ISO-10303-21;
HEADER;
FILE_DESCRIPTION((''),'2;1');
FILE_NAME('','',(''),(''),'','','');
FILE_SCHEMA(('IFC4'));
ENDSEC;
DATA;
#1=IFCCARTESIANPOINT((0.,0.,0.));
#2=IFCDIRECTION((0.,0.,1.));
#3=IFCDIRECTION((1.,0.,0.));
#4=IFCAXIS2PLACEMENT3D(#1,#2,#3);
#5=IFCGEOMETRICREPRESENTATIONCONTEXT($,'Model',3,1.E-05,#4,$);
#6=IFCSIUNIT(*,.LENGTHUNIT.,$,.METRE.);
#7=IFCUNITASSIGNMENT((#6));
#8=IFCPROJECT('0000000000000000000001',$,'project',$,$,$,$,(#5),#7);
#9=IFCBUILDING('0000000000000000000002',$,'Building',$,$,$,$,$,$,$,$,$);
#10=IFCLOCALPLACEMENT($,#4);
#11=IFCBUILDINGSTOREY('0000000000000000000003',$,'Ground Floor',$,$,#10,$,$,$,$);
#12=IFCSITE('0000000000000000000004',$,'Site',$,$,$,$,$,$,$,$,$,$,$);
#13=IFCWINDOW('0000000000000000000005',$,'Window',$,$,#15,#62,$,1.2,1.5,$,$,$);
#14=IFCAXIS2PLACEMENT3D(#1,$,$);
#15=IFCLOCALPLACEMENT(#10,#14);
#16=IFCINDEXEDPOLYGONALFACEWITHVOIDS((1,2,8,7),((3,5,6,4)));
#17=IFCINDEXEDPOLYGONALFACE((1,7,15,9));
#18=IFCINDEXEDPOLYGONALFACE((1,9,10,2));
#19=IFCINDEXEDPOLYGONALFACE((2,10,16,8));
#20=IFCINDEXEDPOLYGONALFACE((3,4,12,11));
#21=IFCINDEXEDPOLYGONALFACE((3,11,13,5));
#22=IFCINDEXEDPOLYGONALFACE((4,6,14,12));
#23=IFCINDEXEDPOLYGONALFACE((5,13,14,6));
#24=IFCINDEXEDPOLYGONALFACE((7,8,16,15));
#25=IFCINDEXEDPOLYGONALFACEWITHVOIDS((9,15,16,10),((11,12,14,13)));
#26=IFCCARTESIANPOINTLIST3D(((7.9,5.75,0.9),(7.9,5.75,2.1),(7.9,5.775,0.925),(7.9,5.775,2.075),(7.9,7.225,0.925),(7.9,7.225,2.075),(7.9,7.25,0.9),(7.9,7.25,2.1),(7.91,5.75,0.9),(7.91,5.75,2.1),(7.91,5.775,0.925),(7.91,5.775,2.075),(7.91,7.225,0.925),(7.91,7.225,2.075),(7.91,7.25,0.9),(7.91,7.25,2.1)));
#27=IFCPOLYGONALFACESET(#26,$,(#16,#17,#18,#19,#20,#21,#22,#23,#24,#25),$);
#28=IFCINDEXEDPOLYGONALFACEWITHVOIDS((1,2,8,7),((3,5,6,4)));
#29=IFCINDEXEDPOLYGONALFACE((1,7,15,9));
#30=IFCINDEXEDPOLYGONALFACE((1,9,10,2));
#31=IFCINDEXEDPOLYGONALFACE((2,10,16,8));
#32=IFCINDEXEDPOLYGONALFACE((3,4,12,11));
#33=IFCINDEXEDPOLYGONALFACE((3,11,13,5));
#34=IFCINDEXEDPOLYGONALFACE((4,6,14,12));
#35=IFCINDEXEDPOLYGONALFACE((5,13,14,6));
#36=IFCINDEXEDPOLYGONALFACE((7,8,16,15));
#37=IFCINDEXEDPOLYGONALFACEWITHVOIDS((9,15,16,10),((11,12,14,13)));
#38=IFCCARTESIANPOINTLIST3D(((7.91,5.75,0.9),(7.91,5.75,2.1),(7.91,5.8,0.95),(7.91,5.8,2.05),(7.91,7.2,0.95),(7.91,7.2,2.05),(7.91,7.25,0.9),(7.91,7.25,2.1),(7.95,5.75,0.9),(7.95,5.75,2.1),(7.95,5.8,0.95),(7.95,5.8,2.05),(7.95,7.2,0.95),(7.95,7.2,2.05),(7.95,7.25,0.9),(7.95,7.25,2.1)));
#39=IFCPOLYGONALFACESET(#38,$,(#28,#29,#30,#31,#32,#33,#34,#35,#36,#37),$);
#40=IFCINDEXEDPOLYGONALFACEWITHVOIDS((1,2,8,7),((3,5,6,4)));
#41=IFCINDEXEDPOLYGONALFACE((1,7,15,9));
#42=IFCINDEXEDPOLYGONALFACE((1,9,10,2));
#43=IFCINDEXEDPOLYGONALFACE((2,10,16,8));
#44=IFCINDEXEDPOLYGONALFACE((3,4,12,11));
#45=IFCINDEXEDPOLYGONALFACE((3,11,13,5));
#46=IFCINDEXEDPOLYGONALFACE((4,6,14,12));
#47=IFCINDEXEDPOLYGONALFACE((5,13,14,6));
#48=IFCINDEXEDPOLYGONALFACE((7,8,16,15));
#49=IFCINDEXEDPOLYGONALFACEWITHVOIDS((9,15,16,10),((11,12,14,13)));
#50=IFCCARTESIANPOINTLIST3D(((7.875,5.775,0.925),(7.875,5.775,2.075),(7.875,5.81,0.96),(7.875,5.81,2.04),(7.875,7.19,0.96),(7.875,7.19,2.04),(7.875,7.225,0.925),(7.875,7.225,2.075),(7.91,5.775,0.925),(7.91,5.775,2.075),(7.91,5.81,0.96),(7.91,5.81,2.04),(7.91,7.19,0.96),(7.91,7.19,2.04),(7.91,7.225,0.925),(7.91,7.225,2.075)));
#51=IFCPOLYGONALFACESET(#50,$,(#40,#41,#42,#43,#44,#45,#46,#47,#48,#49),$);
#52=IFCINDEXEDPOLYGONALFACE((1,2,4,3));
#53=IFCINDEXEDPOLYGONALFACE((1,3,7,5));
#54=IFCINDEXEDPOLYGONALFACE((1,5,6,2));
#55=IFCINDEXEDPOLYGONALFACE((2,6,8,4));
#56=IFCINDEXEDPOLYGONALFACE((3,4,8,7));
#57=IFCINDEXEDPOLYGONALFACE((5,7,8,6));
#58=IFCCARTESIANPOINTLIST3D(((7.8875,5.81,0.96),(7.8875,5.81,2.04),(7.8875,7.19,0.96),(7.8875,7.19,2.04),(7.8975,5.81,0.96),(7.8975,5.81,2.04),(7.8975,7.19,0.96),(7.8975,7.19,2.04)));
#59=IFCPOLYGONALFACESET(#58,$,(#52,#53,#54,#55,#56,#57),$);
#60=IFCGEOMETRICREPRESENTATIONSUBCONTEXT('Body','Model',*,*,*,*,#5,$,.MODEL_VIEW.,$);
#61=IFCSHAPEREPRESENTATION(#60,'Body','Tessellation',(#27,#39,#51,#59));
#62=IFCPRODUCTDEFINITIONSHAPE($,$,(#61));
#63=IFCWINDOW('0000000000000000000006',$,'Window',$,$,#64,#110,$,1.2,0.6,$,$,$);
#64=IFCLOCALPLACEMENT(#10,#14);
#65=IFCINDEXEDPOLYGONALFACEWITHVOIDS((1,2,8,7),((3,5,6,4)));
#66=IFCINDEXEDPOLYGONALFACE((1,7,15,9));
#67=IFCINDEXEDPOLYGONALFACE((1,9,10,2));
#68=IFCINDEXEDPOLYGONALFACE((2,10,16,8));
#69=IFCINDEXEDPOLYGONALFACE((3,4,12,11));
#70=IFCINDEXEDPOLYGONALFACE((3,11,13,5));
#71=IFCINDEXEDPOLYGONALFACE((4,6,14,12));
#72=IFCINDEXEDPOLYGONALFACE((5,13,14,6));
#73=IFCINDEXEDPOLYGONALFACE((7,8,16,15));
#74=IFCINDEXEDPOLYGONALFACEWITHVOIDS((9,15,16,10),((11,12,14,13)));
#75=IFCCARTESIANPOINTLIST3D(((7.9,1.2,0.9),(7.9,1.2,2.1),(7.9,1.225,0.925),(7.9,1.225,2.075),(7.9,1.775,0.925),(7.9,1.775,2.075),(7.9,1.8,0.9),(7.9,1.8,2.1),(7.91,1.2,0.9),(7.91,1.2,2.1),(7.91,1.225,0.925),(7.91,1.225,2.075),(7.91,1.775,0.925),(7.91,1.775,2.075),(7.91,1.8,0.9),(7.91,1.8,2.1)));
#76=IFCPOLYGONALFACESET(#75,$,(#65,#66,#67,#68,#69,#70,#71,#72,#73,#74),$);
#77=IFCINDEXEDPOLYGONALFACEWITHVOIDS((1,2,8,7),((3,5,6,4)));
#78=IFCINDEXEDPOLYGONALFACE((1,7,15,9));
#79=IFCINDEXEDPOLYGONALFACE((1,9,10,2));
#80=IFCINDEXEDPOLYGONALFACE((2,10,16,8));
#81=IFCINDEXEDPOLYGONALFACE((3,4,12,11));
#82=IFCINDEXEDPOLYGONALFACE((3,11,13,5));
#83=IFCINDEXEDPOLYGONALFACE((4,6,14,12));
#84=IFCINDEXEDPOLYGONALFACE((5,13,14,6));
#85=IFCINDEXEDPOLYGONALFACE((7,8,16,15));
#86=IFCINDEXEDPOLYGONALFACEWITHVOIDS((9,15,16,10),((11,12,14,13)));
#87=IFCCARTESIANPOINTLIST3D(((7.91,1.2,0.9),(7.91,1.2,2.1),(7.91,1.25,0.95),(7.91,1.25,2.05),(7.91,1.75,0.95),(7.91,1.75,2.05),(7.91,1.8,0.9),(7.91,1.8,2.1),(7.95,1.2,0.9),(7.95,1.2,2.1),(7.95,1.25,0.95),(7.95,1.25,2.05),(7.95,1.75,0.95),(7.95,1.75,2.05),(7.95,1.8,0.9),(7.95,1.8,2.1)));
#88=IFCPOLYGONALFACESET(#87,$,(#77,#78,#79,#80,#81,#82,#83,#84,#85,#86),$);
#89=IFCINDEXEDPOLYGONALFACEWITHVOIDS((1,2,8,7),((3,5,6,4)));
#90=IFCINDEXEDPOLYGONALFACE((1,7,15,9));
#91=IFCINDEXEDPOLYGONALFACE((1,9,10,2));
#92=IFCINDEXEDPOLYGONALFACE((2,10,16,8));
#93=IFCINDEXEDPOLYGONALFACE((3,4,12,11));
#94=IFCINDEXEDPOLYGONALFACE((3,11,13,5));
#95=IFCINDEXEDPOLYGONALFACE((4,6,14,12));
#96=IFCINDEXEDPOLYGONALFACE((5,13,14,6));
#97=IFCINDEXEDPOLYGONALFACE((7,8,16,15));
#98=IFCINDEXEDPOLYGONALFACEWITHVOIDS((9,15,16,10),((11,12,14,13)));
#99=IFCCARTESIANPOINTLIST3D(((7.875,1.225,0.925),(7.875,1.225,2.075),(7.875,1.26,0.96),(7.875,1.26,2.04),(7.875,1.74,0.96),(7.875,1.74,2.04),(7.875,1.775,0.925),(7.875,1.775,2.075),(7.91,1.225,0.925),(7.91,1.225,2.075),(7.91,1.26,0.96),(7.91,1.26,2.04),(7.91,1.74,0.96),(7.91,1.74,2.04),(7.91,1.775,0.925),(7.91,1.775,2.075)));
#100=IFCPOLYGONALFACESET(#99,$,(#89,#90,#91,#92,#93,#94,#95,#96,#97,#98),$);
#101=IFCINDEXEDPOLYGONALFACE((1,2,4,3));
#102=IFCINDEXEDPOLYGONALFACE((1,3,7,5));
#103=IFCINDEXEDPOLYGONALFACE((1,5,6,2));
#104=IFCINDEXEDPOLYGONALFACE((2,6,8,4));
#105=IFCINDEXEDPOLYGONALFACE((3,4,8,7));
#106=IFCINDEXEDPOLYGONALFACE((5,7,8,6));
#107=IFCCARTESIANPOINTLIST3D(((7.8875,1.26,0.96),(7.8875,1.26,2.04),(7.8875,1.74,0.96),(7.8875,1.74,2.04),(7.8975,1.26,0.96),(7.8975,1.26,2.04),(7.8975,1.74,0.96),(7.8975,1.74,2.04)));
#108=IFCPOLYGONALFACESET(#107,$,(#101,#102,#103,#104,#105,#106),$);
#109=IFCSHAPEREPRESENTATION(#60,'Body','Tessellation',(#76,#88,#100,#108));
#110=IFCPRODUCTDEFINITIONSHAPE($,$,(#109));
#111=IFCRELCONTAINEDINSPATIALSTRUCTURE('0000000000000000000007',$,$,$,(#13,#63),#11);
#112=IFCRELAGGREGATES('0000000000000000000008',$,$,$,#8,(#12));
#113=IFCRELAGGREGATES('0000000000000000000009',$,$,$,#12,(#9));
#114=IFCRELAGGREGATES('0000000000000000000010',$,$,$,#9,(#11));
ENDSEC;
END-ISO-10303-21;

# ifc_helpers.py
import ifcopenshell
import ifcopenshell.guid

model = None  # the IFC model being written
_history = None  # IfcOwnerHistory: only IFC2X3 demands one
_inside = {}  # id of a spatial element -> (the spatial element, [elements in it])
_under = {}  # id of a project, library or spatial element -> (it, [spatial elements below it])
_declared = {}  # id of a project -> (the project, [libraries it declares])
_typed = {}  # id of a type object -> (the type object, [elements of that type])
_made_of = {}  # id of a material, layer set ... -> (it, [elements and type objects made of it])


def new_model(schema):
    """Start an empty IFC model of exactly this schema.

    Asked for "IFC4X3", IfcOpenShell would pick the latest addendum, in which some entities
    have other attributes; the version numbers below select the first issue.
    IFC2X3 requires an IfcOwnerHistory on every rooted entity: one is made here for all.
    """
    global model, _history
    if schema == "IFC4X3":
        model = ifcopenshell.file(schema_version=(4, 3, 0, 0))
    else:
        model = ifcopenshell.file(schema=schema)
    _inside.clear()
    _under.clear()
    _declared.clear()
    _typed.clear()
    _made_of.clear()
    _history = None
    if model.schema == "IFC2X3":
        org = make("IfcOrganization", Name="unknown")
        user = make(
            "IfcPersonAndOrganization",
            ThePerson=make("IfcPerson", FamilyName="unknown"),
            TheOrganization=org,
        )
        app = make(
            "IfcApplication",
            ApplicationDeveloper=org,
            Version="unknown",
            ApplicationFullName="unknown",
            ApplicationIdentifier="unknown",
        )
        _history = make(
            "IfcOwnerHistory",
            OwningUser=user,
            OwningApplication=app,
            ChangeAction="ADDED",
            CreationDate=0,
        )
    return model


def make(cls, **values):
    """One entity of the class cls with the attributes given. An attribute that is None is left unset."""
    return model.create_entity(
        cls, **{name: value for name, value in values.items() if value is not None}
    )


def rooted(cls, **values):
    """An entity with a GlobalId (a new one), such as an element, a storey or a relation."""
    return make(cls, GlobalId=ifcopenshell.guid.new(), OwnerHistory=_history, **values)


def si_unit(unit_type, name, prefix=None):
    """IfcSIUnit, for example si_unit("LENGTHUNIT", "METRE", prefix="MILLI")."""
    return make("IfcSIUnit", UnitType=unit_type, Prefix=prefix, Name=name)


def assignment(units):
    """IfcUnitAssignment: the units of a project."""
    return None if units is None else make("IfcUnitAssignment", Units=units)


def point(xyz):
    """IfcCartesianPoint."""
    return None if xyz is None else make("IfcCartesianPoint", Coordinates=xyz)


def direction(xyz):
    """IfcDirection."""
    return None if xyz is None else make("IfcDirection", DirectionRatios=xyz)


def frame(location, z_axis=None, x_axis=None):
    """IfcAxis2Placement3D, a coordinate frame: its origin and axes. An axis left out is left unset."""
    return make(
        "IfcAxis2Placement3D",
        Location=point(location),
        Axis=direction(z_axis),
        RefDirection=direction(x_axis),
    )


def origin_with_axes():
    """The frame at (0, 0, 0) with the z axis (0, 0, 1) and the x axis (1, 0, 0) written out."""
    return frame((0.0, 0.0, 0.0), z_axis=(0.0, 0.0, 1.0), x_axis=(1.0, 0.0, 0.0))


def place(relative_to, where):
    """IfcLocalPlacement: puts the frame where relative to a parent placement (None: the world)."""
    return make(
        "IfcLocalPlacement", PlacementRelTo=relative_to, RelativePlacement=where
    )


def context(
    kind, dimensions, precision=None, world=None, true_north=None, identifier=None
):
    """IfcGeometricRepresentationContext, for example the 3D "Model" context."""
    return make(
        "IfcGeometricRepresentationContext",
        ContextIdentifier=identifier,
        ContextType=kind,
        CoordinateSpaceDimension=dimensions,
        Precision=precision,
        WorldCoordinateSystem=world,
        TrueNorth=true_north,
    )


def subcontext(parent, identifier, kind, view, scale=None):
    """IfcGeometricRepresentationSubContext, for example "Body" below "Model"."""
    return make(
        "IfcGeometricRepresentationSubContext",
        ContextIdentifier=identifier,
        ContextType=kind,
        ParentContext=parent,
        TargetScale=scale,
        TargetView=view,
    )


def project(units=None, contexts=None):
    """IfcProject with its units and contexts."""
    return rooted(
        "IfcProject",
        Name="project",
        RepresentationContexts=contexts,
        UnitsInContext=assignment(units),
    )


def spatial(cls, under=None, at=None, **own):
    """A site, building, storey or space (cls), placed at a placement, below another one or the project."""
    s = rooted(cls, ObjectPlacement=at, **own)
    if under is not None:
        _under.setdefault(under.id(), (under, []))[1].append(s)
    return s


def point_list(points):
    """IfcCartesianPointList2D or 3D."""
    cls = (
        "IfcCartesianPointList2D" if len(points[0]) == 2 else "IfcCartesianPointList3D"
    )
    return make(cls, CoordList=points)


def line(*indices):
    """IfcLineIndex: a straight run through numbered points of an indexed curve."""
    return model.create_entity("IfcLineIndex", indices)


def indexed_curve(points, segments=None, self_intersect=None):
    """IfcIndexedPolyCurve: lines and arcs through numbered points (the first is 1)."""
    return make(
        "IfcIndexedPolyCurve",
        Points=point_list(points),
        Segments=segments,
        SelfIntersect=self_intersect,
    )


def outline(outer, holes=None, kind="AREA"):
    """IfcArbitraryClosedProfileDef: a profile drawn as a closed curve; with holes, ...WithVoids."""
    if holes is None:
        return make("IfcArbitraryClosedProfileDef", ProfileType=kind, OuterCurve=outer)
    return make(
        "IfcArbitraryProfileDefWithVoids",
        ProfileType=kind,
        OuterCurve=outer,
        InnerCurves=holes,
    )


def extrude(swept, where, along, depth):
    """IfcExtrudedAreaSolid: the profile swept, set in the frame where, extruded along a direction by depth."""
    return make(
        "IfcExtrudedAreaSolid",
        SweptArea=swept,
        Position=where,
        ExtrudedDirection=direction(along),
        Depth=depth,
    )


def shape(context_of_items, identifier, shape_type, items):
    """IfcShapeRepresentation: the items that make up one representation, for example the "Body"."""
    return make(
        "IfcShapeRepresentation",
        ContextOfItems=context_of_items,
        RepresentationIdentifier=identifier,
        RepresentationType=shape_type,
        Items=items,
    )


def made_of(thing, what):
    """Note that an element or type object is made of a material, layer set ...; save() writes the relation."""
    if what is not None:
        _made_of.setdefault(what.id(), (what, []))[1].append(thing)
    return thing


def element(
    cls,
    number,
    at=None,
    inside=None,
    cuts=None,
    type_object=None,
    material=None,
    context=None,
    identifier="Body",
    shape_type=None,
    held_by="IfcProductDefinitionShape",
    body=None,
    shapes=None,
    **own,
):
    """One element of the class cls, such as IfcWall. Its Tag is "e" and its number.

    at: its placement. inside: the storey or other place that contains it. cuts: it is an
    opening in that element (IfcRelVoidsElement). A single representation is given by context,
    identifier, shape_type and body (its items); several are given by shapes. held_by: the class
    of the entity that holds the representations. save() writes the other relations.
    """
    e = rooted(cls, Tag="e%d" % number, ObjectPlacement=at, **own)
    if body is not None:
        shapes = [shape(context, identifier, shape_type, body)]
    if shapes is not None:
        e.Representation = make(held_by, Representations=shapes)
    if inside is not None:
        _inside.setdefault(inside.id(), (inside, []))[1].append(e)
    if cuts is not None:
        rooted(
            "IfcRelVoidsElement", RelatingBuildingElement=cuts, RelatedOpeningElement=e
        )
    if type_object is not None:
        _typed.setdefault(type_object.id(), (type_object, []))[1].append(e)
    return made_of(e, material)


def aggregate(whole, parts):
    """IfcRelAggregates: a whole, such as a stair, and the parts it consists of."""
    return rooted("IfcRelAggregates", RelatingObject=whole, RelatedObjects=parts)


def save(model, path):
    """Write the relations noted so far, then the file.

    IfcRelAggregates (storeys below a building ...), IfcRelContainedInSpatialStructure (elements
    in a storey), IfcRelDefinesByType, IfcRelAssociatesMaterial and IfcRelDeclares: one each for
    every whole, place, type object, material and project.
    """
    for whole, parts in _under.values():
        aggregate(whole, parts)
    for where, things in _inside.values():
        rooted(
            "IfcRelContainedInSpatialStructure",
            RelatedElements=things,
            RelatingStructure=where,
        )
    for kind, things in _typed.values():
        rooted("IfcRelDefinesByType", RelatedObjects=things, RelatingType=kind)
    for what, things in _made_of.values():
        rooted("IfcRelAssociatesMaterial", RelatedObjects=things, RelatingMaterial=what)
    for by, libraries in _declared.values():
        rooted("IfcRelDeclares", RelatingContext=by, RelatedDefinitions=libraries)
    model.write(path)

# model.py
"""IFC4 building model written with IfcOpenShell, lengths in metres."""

from ifc_helpers import new_model, si_unit, frame, origin_with_axes, place, context, subcontext, project, spatial, line, indexed_curve, outline, extrude, element, save


model = new_model("IFC4")

# Units and contexts
model_context = context("Model", 3, precision=1e-05, world=origin_with_axes())
body_context = subcontext(model_context, "Body", "Model", "MODEL_VIEW")
ifc_project = project(units=[si_unit("LENGTHUNIT", "METRE")], contexts=[model_context])

# Site, building, storey
site = spatial("IfcSite", under=ifc_project, Name="Site")
building = spatial("IfcBuilding", under=site, Name="Building")
storey_placement = place(None, origin_with_axes())
storey = spatial("IfcBuildingStorey", under=building, at=storey_placement, Name="Ground Floor")

# Windows
for number, where, z_axis, x_axis, name in (
    (1, (8.0, 5.75, 0.9), (0.0, 0.0, 1.0), (0.0, 1.0, 0.0), "Window"),
):
    element("IfcWindow", number, at=place(storey_placement, frame(where, z_axis=z_axis, x_axis=x_axis)), inside=storey, Name=name, OverallHeight=1.2, OverallWidth=1.5, context=body_context, shape_type="SweptSolid", body=[
        extrude(outline(indexed_curve([(0.0, 0.0), (1.5, 0.0), (1.5, 1.2), (0.0, 1.2)], segments=[line(1, 2, 3, 4, 1)]), holes=[indexed_curve([(0.025, 0.025), (1.475, 0.025), (1.475, 1.175), (0.025, 1.175)], segments=[line(1, 2, 3, 4, 1)])]), frame((0.0, 0.09, 0.0), z_axis=(0.0, -1.0, 0.0), x_axis=(1.0, 0.0, 0.0)), (0.0, 0.0, -1.0), 0.01),
        extrude(outline(indexed_curve([(0.0, 0.0), (1.5, 0.0), (1.5, 1.2), (0.0, 1.2)], segments=[line(1, 2, 3, 4, 1)]), holes=[indexed_curve([(0.05, 0.05), (1.45, 0.05), (1.45, 1.15), (0.05, 1.15)], segments=[line(1, 2, 3, 4, 1)])]), frame((0.0, 0.05, 0.0), z_axis=(0.0, -1.0, 0.0), x_axis=(1.0, 0.0, 0.0)), (0.0, 0.0, -1.0), 0.04),
        extrude(outline(indexed_curve([(0.0, 0.0), (1.45, 0.0), (1.45, 1.15), (0.0, 1.15)], segments=[line(1, 2, 3, 4, 1)]), holes=[indexed_curve([(0.035, 0.035), (1.415, 0.035), (1.415, 1.115), (0.035, 1.115)], segments=[line(1, 2, 3, 4, 1)])]), frame((0.025, 0.09, 0.025), z_axis=(0.0, -1.0, 0.0), x_axis=(1.0, 0.0, 0.0)), (0.0, 0.0, -1.0), 0.035),
        extrude(outline(indexed_curve([(0.035, 0.035), (1.415, 0.035), (1.415, 1.115), (0.035, 1.115)], segments=[line(1, 2, 3, 4, 1)])), frame((0.025, 0.1025, 0.025), z_axis=(0.0, -1.0, 0.0), x_axis=(1.0, 0.0, 0.0)), (0.0, 0.0, -1.0), 0.01),
    ])
window_1_placement = place(storey_placement, frame((8.0, 1.2, 0.9), z_axis=(0.0, 0.0, 1.0), x_axis=(0.0, 1.0, 0.0)))
element("IfcWindow", 2, at=window_1_placement, inside=storey, Name="Window", OverallHeight=1.2, OverallWidth=0.6, context=body_context, shape_type="SweptSolid", body=[
    extrude(outline(indexed_curve([(0.0, 0.0), (0.6, 0.0), (0.6, 1.2), (0.0, 1.2)], segments=[line(1, 2, 3, 4, 1)]), holes=[indexed_curve([(0.025, 0.025), (0.575, 0.025), (0.575, 1.175), (0.025, 1.175)], segments=[line(1, 2, 3, 4, 1)])]), frame((0.0, 0.09, 0.0), z_axis=(0.0, -1.0, 0.0), x_axis=(1.0, 0.0, 0.0)), (0.0, 0.0, -1.0), 0.01),
    extrude(outline(indexed_curve([(0.0, 0.0), (0.6, 0.0), (0.6, 1.2), (0.0, 1.2)], segments=[line(1, 2, 3, 4, 1)]), holes=[indexed_curve([(0.05, 0.05), (0.55, 0.05), (0.55, 1.15), (0.05, 1.15)], segments=[line(1, 2, 3, 4, 1)])]), frame((0.0, 0.05, 0.0), z_axis=(0.0, -1.0, 0.0), x_axis=(1.0, 0.0, 0.0)), (0.0, 0.0, -1.0), 0.04),
    extrude(outline(indexed_curve([(0.0, 0.0), (0.55, 0.0), (0.55, 1.15), (0.0, 1.15)], segments=[line(1, 2, 3, 4, 1)]), holes=[indexed_curve([(0.035, 0.035), (0.515, 0.035), (0.515, 1.115), (0.035, 1.115)], segments=[line(1, 2, 3, 4, 1)])]), frame((0.025, 0.09, 0.025), z_axis=(0.0, -1.0, 0.0), x_axis=(1.0, 0.0, 0.0)), (0.0, 0.0, -1.0), 0.035),
    extrude(outline(indexed_curve([(0.035, 0.035), (0.515, 0.035), (0.515, 1.115), (0.035, 1.115)], segments=[line(1, 2, 3, 4, 1)])), frame((0.025, 0.1025, 0.025), z_axis=(0.0, -1.0, 0.0), x_axis=(1.0, 0.0, 0.0)), (0.0, 0.0, -1.0), 0.01),
])

save(model, "model.ifc")
